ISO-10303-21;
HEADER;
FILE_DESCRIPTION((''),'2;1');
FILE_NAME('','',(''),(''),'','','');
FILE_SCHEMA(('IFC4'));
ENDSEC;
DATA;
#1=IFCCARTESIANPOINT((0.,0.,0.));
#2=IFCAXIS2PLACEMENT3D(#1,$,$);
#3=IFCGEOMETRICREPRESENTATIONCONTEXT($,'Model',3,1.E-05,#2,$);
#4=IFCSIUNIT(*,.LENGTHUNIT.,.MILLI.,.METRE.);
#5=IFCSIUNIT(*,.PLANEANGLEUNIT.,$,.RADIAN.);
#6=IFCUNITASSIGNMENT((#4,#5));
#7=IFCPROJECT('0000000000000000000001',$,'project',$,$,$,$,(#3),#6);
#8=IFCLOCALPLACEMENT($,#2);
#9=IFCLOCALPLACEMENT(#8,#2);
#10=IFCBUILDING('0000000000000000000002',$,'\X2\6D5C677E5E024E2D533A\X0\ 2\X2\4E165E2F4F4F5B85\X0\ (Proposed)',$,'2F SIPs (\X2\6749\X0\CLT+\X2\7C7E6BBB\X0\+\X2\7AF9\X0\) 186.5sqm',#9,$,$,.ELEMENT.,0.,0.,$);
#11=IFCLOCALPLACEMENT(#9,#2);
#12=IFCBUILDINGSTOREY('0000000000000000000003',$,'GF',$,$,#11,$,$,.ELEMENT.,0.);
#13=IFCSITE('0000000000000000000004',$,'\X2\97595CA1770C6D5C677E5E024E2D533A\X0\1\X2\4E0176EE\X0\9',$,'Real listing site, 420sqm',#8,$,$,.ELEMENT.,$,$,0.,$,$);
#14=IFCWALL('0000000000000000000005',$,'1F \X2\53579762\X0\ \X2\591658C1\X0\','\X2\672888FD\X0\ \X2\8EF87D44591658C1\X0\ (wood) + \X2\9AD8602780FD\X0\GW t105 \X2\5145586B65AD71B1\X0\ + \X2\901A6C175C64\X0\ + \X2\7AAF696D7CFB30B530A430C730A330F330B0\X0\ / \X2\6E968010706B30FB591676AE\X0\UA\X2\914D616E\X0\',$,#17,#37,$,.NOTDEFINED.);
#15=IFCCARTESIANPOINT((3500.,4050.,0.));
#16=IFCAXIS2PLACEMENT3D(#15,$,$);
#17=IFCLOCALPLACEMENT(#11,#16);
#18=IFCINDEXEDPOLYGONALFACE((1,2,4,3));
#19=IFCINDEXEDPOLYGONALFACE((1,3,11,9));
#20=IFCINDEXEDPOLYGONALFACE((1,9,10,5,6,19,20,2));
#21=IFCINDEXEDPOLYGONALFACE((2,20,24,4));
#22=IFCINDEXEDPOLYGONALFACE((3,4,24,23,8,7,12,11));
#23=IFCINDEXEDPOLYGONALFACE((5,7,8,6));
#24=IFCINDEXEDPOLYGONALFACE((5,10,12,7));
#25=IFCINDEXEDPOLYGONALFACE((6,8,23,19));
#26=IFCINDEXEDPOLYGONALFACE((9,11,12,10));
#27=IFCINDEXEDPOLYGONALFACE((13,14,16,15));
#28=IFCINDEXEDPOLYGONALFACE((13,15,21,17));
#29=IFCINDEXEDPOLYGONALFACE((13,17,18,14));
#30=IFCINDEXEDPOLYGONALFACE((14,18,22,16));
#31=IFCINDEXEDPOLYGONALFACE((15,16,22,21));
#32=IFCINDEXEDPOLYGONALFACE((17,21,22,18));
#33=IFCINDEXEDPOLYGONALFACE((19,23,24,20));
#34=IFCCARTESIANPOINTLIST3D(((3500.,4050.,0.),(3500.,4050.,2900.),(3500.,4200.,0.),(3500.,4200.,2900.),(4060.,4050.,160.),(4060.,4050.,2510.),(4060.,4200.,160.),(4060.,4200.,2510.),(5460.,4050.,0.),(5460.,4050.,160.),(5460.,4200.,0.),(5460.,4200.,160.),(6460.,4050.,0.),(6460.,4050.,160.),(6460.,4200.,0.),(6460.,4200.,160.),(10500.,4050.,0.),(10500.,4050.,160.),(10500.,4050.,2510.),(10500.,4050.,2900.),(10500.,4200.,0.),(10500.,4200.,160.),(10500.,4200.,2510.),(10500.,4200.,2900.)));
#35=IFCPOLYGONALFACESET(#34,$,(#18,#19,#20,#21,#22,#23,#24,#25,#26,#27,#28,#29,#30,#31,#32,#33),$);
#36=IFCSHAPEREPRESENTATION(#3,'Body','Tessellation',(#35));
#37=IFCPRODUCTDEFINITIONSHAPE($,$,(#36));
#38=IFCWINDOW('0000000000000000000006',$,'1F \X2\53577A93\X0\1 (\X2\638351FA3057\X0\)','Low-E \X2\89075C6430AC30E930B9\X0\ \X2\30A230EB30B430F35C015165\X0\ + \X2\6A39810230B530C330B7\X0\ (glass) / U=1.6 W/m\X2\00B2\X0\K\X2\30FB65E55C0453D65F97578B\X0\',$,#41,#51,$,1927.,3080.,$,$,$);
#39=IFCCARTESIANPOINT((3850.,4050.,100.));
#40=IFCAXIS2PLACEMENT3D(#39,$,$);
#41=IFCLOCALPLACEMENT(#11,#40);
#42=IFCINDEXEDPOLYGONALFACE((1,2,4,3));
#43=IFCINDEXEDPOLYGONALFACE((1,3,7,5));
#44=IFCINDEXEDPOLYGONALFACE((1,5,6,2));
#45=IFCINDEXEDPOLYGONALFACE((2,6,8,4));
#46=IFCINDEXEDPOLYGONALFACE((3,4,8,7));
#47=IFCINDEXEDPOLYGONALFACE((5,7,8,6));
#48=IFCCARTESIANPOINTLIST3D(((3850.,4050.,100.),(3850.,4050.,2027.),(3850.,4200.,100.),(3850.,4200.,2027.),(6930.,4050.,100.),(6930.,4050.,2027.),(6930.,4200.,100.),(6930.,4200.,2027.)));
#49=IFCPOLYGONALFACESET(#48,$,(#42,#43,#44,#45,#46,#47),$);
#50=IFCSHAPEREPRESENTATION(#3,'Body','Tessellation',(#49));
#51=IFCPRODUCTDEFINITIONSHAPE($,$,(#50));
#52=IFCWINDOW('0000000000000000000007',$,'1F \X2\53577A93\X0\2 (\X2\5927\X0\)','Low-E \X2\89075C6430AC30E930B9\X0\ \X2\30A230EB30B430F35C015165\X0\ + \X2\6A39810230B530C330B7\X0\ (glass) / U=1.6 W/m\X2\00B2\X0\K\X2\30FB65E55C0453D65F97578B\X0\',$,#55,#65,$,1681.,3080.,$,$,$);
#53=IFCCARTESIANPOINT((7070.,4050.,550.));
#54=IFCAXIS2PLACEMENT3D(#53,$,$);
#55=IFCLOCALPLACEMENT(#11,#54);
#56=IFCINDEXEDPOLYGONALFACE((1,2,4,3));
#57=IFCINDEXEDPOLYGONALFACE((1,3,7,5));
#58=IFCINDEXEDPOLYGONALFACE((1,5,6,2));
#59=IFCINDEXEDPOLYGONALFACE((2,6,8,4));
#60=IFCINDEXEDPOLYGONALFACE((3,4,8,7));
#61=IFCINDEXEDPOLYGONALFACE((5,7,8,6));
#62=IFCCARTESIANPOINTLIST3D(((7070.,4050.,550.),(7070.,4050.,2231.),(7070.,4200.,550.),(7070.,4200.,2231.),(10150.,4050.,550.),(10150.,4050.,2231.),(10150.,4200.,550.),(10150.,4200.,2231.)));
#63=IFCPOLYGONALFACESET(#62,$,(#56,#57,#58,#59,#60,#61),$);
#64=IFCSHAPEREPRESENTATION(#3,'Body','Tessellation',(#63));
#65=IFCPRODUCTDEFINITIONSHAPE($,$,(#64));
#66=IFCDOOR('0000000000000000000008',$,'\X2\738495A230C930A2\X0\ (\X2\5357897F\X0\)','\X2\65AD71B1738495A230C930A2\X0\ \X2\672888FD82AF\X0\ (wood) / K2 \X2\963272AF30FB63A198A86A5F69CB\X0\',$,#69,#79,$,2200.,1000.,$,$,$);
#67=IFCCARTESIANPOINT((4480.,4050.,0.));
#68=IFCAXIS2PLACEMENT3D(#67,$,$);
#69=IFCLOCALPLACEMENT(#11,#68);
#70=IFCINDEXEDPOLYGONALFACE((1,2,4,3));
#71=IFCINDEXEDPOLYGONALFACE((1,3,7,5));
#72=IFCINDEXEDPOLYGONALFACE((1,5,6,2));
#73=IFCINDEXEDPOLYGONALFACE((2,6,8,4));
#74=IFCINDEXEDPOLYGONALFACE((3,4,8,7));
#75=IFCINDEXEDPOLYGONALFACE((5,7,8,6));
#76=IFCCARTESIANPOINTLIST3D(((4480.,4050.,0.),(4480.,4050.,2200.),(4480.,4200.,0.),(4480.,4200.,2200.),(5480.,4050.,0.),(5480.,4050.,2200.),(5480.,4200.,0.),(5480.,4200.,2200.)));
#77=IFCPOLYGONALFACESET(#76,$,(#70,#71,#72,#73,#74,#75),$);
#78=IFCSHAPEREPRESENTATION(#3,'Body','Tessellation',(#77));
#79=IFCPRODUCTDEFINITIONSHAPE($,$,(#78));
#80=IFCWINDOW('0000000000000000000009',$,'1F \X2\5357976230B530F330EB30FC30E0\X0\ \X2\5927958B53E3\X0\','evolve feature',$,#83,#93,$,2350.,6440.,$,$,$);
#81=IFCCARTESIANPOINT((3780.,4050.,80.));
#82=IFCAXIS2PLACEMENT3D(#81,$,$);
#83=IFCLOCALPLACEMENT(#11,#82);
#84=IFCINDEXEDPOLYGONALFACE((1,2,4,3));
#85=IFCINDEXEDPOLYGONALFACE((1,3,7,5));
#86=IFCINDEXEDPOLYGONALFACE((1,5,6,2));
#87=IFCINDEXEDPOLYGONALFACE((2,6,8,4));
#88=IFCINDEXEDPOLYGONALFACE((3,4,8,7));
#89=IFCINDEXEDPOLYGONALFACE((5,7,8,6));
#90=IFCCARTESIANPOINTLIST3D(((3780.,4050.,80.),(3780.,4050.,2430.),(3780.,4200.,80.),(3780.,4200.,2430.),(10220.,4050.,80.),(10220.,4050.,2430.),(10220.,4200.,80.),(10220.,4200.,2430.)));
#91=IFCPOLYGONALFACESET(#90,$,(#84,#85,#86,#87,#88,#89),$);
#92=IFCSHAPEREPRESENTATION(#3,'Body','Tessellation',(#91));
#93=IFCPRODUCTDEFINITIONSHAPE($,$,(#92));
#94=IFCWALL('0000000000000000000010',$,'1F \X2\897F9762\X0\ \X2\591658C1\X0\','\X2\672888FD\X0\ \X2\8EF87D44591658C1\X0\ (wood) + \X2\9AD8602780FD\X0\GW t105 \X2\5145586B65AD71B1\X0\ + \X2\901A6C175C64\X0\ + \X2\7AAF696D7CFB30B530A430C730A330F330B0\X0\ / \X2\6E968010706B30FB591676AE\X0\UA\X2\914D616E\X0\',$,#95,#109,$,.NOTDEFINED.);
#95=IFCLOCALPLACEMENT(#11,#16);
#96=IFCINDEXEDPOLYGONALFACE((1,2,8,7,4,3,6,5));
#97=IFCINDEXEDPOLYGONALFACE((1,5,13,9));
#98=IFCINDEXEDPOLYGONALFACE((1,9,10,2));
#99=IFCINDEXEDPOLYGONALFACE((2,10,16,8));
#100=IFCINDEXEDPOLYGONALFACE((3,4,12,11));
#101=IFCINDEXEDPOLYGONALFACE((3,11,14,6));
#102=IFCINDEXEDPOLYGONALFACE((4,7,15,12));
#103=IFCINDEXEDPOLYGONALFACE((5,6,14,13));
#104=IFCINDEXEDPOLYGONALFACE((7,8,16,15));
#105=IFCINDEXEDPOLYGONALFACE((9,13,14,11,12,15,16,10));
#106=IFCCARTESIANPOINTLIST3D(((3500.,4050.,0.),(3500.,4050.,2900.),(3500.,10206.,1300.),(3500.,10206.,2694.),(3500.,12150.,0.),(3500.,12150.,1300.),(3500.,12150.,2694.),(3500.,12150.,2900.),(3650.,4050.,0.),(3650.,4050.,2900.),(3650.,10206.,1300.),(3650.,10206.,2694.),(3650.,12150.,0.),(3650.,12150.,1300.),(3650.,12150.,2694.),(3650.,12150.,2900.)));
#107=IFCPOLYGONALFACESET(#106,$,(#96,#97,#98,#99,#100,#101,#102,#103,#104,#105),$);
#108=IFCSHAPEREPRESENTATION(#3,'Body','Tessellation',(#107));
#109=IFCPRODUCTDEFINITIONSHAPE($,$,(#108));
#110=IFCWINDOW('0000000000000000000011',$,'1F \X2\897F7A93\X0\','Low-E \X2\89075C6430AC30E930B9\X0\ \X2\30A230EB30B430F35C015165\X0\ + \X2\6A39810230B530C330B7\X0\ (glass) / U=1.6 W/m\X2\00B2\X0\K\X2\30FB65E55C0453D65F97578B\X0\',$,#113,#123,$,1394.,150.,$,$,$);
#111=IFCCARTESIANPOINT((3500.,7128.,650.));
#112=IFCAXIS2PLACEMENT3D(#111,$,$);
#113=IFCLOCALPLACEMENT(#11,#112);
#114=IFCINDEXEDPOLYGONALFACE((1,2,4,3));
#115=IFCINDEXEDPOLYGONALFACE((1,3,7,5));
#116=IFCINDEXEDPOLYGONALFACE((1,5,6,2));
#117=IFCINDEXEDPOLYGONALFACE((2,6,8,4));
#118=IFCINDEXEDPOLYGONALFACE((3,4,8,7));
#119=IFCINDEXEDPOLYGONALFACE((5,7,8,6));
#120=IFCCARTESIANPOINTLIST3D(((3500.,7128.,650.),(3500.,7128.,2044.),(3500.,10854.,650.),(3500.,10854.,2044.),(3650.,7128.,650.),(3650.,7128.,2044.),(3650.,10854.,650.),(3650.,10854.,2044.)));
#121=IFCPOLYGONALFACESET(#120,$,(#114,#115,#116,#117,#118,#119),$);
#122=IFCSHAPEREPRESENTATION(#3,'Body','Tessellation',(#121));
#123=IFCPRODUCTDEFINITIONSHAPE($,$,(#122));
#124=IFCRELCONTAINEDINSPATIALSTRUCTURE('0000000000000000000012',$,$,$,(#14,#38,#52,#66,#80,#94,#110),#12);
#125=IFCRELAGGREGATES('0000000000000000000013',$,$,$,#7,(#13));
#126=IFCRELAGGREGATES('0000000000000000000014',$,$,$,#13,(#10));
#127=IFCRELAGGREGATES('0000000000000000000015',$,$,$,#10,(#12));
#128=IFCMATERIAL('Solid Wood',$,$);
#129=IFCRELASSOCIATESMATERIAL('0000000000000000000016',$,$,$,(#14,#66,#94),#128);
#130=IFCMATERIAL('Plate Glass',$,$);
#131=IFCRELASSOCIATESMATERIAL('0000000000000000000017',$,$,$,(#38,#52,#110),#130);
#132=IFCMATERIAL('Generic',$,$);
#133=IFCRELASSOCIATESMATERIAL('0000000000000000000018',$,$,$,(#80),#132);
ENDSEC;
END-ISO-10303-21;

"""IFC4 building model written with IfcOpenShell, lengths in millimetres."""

from ifc_helpers import new_model, si_unit, frame, frame_2d, origin, place, context, project, spatial, rectangle, extrude, material, element, fill, save


model = new_model("IFC4")

# Units and contexts
model_context = context("Model", 3, precision=1e-05, world=origin())
ifc_project = project(units=[si_unit("LENGTHUNIT", "METRE", prefix="MILLI"), si_unit("PLANEANGLEUNIT", "RADIAN")], contexts=[model_context])

# Site, building, storey
site_placement = place(None, origin())
site = spatial("IfcSite", under=ifc_project, at=site_placement, Name="静岡県浜松市中区1丁目9", ObjectType="Real listing site, 420sqm", CompositionType="ELEMENT", RefElevation=0.0)
building_placement = place(site_placement, origin())
building = spatial("IfcBuilding", under=site, at=building_placement, Name="浜松市中区 2世帯住宅 (Proposed)", ObjectType="2F SIPs (杉CLT+籾殻+竹) 186.5sqm", CompositionType="ELEMENT", ElevationOfRefHeight=0.0, ElevationOfTerrain=0.0)
storey_placement = place(building_placement, origin())
storey = spatial("IfcBuildingStorey", under=building, at=storey_placement, Name="GF", CompositionType="ELEMENT", Elevation=0.0)

# Shared definitions
ifc_material_1 = material(Name="Solid Wood")
ifc_material_2 = material(Name="Generic")

# Wall, openings, windows, door
wall_1_placement = place(storey_placement, frame((3500.0, 4050.0, 0.0)))
wall_1 = element("IfcWall", 1, at=wall_1_placement, inside=storey, material=ifc_material_1, Name="1F 南面 外壁", Description="木製 軸組外壁 (wood) + 高性能GW t105 充填断熱 + 通気層 + 窯業系サイディング / 準耐火・外皮UA配慮", PredefinedType="NOTDEFINED", context=model_context, shape_type="SweptSolid", body=[
    extrude(rectangle(XDim=7000.0, YDim=150.0, at=frame_2d((3500.0, 75.0))), frame((3500.0, 4050.0, 0.0)), (0.0, 0.0, 1.0), 2900.0),
])
opening_1_placement = place(storey_placement, frame((3850.0, 4050.0, 100.0)))
opening_1 = element("IfcOpeningElement", 2, at=opening_1_placement, cuts=wall_1, PredefinedType="NOTDEFINED", context=model_context, shape_type="SweptSolid", body=[
    extrude(rectangle(XDim=3080.0, YDim=150.0, at=frame_2d((1540.0, 75.0))), frame((3850.0, 4050.0, 100.0)), (0.0, 0.0, 1.0), 1927.0),
])
opening_2_placement = place(storey_placement, frame((7070.0, 4050.0, 550.0)))
opening_2 = element("IfcOpeningElement", 3, at=opening_2_placement, cuts=wall_1, PredefinedType="NOTDEFINED", context=model_context, shape_type="SweptSolid", body=[
    extrude(rectangle(XDim=3080.0, YDim=150.0, at=frame_2d((1540.0, 75.0))), frame((7070.0, 4050.0, 550.0)), (0.0, 0.0, 1.0), 1681.0),
])
opening_3_placement = place(storey_placement, frame((4480.0, 4050.0, 0.0)))
opening_3 = element("IfcOpeningElement", 4, at=opening_3_placement, cuts=wall_1, PredefinedType="NOTDEFINED", context=model_context, shape_type="SweptSolid", body=[
    extrude(rectangle(XDim=1000.0, YDim=150.0, at=frame_2d((500.0, 75.0))), frame((4480.0, 4050.0, 0.0)), (0.0, 0.0, 1.0), 2200.0),
])
opening_4_placement = place(storey_placement, frame((3780.0, 4050.0, 80.0)))
opening_4 = element("IfcOpeningElement", 5, at=opening_4_placement, cuts=wall_1, PredefinedType="NOTDEFINED", context=model_context, shape_type="SweptSolid", body=[
    extrude(rectangle(XDim=6440.0, YDim=150.0, at=frame_2d((3220.0, 75.0))), frame((3780.0, 4050.0, 80.0)), (0.0, 0.0, 1.0), 2350.0),
])
ifc_material_3 = material(Name="Plate Glass")
window_1_placement = place(storey_placement, frame((3850.0, 4050.0, 100.0)))
window_1 = element("IfcWindow", 6, at=window_1_placement, inside=storey, material=ifc_material_3, Name="1F 南窓1 (掃出し)", Description="Low-E 複層ガラス アルゴン封入 + 樹脂サッシ (glass) / U=1.6 W/m²K・日射取得型", OverallHeight=1927.0, OverallWidth=3080.0, context=model_context, shape_type="SweptSolid", body=[
    extrude(rectangle(XDim=3080.0, YDim=150.0, at=frame_2d((1540.0, 75.0))), frame((3850.0, 4050.0, 100.0)), (0.0, 0.0, 1.0), 1927.0),
])
fill(opening_1, window_1)
window_2_placement = place(storey_placement, frame((7070.0, 4050.0, 550.0)))
window_2 = element("IfcWindow", 7, at=window_2_placement, inside=storey, material=ifc_material_3, Name="1F 南窓2 (大)", Description="Low-E 複層ガラス アルゴン封入 + 樹脂サッシ (glass) / U=1.6 W/m²K・日射取得型", OverallHeight=1681.0, OverallWidth=3080.0, context=model_context, shape_type="SweptSolid", body=[
    extrude(rectangle(XDim=3080.0, YDim=150.0, at=frame_2d((1540.0, 75.0))), frame((7070.0, 4050.0, 550.0)), (0.0, 0.0, 1.0), 1681.0),
])
fill(opening_2, window_2)
door_placement = place(storey_placement, frame((4480.0, 4050.0, 0.0)))
door = element("IfcDoor", 8, at=door_placement, inside=storey, material=ifc_material_1, Name="玄関ドア (南西)", Description="断熱玄関ドア 木製芯 (wood) / K2 防犯・採風機構", OverallHeight=2200.0, OverallWidth=1000.0, context=model_context, shape_type="SweptSolid", body=[
    extrude(rectangle(XDim=1000.0, YDim=150.0, at=frame_2d((500.0, 75.0))), frame((4480.0, 4050.0, 0.0)), (0.0, 0.0, 1.0), 2200.0),
])
fill(opening_3, door)
window_3_placement = place(storey_placement, frame((3780.0, 4050.0, 80.0)))
window_3 = element("IfcWindow", 9, at=window_3_placement, inside=storey, material=ifc_material_2, Name="1F 南面サンルーム 大開口", Description="evolve feature", OverallHeight=2350.0, OverallWidth=6440.0, context=model_context, shape_type="SweptSolid", body=[
    extrude(rectangle(XDim=6440.0, YDim=150.0, at=frame_2d((3220.0, 75.0))), frame((3780.0, 4050.0, 80.0)), (0.0, 0.0, 1.0), 2350.0),
])
fill(opening_4, window_3)

# Wall, opening, window
wall_2_placement = place(storey_placement, frame((3500.0, 4050.0, 0.0)))
wall_2 = element("IfcWall", 10, at=wall_2_placement, inside=storey, material=ifc_material_1, Name="1F 西面 外壁", Description="木製 軸組外壁 (wood) + 高性能GW t105 充填断熱 + 通気層 + 窯業系サイディング / 準耐火・外皮UA配慮", PredefinedType="NOTDEFINED", context=model_context, shape_type="SweptSolid", body=[
    extrude(rectangle(XDim=150.0, YDim=8100.0, at=frame_2d((75.0, 4050.0))), frame((3500.0, 4050.0, 0.0)), (0.0, 0.0, 1.0), 2900.0),
])
opening_5_placement = place(storey_placement, frame((3500.0, 7128.0, 650.0)))
opening_5 = element("IfcOpeningElement", 11, at=opening_5_placement, cuts=wall_2, PredefinedType="NOTDEFINED", context=model_context, shape_type="SweptSolid", body=[
    extrude(rectangle(XDim=150.0, YDim=3726.0, at=frame_2d((75.0, 1863.0))), frame((3500.0, 7128.0, 650.0)), (0.0, 0.0, 1.0), 1394.0),
])
window_4_placement = place(storey_placement, frame((3500.0, 7128.0, 650.0)))
window_4 = element("IfcWindow", 12, at=window_4_placement, inside=storey, material=ifc_material_3, Name="1F 西窓", Description="Low-E 複層ガラス アルゴン封入 + 樹脂サッシ (glass) / U=1.6 W/m²K・日射取得型", OverallHeight=1394.0, OverallWidth=150.0, context=model_context, shape_type="SweptSolid", body=[
    extrude(rectangle(XDim=150.0, YDim=3726.0, at=frame_2d((75.0, 1863.0))), frame((3500.0, 7128.0, 650.0)), (0.0, 0.0, 1.0), 1394.0),
])
fill(opening_5, window_4)

save(model, "model.ifc")
